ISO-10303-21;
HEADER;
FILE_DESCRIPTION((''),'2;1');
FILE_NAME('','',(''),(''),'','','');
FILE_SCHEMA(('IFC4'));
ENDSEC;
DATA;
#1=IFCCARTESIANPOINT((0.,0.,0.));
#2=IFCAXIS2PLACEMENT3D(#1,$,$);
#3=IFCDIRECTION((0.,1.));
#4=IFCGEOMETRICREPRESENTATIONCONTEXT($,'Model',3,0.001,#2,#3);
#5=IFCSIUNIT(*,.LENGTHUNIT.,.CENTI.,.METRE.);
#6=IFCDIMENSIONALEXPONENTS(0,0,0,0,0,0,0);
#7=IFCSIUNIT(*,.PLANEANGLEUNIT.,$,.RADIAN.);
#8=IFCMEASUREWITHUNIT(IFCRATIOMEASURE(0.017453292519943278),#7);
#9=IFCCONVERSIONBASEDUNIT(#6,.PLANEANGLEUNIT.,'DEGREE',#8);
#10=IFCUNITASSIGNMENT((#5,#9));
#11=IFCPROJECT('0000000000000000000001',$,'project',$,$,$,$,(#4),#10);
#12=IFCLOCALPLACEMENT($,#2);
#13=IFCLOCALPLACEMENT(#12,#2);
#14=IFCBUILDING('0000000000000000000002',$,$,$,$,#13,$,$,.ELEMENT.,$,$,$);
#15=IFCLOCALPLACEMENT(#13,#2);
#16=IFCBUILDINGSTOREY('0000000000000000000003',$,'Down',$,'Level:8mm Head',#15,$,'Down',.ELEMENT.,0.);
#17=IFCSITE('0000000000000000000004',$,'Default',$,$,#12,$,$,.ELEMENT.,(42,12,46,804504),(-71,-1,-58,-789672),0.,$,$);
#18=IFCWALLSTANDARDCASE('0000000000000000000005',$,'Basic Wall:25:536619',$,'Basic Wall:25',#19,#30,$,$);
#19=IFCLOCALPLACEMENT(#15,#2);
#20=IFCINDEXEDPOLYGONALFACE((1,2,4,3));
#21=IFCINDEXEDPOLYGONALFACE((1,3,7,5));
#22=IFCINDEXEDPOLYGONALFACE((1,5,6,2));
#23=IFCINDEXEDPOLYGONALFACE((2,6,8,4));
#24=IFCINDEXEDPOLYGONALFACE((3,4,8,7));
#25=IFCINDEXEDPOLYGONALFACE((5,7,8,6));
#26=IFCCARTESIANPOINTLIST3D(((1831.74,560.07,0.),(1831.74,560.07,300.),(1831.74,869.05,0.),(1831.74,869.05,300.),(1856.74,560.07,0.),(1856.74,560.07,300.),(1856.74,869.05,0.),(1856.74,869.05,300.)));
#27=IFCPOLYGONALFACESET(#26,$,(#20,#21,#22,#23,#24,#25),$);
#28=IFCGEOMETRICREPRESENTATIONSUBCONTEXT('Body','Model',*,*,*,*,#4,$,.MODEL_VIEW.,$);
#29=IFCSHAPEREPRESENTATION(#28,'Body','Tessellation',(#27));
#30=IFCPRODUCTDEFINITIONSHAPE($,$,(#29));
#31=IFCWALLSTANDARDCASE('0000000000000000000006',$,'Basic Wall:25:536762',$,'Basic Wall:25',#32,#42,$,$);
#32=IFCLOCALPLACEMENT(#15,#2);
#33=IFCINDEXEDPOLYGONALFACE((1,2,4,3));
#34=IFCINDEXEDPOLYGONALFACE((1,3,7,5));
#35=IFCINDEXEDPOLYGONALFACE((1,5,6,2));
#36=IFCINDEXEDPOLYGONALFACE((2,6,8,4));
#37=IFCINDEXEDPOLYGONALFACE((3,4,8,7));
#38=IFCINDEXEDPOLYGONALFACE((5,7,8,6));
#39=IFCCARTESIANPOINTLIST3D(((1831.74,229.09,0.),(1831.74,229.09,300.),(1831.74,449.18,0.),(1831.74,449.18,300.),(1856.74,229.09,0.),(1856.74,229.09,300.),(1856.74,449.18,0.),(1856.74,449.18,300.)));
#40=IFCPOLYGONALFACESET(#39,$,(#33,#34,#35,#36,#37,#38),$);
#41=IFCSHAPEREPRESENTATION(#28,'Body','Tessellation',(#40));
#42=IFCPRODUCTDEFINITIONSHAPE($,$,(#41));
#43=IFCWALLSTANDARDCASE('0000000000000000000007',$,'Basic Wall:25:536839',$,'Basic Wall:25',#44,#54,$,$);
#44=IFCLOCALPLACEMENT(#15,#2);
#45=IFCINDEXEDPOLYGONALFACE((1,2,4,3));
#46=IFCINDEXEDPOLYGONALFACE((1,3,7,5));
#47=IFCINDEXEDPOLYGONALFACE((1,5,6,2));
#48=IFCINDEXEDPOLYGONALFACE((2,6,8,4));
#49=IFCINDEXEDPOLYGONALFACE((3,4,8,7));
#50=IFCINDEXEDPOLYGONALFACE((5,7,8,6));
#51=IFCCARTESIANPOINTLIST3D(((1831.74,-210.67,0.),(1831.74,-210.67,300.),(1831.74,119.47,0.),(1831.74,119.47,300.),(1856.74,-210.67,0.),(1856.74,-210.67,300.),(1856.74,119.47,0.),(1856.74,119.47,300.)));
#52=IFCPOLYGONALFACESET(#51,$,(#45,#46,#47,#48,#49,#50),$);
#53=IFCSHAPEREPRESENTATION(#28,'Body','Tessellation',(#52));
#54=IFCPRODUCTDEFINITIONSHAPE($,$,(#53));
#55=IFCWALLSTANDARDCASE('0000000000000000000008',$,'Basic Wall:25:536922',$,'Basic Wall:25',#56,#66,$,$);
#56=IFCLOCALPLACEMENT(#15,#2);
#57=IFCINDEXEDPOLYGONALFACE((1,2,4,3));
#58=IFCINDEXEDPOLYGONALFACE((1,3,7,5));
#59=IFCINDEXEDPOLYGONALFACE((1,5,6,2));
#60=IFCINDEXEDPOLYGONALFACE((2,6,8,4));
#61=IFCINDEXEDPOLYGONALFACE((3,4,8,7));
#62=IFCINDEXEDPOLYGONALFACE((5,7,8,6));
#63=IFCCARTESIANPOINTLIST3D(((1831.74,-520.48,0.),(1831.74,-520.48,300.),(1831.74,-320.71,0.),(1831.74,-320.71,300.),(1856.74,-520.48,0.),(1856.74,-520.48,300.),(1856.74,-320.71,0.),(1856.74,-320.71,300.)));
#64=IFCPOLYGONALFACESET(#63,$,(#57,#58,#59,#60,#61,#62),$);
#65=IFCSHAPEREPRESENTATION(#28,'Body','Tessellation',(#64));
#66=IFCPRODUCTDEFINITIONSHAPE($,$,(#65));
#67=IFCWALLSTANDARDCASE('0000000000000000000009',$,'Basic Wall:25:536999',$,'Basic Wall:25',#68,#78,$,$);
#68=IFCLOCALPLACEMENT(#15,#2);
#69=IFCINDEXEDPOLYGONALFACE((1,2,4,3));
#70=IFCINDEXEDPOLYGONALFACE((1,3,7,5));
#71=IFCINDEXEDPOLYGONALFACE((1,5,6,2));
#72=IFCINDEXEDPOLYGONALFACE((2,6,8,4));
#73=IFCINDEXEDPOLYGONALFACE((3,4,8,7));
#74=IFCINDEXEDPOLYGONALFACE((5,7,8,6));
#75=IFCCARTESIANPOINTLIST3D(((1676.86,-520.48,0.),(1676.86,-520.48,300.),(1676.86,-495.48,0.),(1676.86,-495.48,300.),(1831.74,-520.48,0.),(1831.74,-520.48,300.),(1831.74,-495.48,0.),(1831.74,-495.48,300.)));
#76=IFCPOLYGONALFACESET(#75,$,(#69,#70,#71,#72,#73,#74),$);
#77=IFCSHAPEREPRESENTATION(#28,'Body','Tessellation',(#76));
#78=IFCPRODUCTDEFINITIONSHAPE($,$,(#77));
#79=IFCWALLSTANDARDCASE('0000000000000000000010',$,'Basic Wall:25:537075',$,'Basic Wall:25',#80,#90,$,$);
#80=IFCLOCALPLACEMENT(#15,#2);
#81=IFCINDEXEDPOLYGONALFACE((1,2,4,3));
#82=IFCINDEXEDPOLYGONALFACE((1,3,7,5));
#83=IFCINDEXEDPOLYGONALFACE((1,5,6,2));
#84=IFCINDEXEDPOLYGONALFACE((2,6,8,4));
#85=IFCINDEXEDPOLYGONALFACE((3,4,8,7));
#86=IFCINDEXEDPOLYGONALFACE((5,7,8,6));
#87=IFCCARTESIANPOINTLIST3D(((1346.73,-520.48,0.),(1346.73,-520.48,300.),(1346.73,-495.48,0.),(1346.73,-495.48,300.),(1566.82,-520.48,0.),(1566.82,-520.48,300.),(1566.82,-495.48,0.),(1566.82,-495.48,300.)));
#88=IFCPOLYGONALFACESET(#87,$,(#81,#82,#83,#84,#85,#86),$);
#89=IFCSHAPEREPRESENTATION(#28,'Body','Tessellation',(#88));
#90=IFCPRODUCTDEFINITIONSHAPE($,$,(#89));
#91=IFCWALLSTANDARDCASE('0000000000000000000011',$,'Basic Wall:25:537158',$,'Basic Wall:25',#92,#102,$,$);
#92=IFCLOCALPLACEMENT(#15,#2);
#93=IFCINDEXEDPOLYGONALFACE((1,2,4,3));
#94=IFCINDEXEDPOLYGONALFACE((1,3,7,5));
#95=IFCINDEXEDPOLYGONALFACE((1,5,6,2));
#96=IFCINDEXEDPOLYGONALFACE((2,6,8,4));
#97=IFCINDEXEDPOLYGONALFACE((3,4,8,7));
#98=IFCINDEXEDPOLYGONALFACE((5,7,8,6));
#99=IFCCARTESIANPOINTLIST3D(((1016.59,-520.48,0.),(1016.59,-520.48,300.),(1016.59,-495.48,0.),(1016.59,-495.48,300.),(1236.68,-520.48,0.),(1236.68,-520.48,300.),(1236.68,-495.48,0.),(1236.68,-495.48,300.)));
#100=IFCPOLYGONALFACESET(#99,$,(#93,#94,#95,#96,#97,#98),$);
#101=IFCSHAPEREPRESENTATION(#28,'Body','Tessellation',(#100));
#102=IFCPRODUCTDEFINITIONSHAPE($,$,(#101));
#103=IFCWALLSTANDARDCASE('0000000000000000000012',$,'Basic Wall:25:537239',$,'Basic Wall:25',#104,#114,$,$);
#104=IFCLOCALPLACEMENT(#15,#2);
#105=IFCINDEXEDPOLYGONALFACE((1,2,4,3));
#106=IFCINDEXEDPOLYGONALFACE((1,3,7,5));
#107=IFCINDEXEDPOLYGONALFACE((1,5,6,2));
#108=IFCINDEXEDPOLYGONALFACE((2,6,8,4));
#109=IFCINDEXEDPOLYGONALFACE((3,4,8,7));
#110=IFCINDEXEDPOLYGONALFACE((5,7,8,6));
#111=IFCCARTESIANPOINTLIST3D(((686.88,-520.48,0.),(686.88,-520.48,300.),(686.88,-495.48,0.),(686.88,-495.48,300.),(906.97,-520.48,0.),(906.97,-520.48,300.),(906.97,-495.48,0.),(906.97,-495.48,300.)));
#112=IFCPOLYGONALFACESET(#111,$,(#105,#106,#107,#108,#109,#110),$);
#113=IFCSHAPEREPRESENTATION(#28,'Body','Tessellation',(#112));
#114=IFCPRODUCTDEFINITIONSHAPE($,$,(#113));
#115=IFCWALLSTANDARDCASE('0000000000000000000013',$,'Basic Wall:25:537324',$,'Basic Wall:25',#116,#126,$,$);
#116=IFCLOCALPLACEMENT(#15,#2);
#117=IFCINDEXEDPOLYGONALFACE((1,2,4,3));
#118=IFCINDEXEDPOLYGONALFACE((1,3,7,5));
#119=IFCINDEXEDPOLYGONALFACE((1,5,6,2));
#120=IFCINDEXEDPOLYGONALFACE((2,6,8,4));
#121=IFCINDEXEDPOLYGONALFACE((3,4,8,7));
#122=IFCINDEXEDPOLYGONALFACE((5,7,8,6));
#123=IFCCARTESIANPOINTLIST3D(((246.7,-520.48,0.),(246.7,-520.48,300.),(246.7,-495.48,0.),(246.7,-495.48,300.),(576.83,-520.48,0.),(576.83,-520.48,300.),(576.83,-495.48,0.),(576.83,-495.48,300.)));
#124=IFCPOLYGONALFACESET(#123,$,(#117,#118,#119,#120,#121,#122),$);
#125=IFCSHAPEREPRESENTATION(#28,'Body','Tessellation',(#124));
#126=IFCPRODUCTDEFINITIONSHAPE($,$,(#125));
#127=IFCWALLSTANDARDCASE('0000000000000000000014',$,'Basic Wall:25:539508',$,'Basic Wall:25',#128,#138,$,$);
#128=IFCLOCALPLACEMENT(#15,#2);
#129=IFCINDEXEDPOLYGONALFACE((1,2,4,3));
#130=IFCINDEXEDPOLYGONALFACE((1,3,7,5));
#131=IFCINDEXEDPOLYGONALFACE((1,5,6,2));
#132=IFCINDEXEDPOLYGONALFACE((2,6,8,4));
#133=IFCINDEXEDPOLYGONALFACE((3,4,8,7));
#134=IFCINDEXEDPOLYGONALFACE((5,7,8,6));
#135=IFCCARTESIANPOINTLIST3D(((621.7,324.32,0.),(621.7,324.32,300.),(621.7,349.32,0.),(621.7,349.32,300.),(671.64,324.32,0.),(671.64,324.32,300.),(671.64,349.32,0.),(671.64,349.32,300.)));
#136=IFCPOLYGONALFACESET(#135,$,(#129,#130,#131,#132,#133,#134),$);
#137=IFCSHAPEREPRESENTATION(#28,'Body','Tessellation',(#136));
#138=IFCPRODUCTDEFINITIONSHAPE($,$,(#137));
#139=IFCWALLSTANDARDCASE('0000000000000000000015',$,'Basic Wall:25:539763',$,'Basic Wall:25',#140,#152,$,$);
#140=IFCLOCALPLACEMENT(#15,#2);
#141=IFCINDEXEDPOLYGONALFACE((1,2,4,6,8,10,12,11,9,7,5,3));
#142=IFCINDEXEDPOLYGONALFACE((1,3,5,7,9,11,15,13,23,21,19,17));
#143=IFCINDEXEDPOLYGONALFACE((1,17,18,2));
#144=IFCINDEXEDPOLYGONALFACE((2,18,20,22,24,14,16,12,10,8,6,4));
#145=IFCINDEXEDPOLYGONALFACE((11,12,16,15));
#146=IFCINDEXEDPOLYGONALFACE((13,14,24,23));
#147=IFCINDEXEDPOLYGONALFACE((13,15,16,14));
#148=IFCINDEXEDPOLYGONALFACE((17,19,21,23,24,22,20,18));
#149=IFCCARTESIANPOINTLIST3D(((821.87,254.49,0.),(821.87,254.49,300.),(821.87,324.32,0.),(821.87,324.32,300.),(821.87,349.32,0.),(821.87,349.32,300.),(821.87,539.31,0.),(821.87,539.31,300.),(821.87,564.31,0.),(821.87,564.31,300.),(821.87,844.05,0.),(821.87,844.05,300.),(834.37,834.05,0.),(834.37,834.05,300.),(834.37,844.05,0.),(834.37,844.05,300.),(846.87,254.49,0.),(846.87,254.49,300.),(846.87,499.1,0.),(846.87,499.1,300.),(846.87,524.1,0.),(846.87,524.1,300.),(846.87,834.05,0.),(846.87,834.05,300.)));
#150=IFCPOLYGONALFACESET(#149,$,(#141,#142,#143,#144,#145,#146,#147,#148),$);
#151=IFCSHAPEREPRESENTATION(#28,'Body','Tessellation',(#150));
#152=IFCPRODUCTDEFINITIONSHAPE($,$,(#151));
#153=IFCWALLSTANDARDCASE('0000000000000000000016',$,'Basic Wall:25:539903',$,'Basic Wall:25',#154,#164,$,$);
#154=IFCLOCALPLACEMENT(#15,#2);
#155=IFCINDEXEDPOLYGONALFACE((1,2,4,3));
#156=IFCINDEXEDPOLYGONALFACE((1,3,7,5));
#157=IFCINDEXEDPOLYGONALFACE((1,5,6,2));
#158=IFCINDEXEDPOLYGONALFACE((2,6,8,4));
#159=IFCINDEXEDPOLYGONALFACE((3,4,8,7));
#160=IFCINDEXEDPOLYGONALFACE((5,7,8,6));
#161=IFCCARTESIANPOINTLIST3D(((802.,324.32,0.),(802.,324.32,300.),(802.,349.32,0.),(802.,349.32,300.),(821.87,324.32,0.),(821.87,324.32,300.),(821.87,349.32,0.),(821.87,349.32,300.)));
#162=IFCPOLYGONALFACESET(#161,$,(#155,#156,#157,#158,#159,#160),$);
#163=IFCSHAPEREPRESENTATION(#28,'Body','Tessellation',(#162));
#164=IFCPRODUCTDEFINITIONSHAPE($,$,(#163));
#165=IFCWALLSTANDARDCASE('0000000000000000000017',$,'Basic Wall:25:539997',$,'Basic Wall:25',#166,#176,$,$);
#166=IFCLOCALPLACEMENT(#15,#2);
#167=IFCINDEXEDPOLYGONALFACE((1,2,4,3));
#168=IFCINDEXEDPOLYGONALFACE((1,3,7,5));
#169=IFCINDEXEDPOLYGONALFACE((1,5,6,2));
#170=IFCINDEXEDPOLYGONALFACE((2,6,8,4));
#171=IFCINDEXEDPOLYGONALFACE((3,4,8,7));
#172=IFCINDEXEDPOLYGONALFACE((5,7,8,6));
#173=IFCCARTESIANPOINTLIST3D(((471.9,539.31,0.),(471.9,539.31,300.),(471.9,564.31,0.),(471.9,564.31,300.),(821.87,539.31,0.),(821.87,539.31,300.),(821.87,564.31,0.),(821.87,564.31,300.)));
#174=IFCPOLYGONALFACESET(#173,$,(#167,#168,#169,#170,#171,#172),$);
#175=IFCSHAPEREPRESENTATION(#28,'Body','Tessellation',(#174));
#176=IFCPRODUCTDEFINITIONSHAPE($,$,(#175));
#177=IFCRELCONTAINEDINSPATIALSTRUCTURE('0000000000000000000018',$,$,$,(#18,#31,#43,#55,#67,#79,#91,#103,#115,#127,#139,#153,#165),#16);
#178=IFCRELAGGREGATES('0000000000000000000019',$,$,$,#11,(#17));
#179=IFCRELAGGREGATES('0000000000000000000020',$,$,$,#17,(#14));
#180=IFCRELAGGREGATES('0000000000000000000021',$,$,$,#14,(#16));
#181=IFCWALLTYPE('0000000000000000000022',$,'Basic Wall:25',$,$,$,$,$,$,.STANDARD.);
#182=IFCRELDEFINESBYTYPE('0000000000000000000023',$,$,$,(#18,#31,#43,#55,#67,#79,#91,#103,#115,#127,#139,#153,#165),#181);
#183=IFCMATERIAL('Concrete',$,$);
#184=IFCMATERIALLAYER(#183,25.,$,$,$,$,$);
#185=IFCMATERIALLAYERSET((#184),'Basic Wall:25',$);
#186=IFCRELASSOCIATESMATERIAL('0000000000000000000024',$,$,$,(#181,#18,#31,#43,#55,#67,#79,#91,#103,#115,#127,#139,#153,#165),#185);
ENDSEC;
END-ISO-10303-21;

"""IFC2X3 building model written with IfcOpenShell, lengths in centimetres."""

from ifc_helpers import new_model, entity, si_unit, converted_unit, direction, frame, frame_2d, origin, place, context, subcontext, project, spatial, polyline, rectangle, outline, extrude, material, layer, layer_set, layer_usage, type_object, element, save


model = new_model("IFC2X3")

# Units and contexts
model_context = context("Model", 3, precision=0.001, world=origin(), true_north=direction((0.0, 1.0)))
body_context = subcontext(model_context, "Body", "Model", "MODEL_VIEW")
ifc_project = project(units=[si_unit("LENGTHUNIT", "METRE", prefix="CENTI"), converted_unit("PLANEANGLEUNIT", "DEGREE", entity("IfcRatioMeasure", 0.017453292519943278), si_unit("PLANEANGLEUNIT", "RADIAN"), dimensions=[0, 0, 0, 0, 0, 0, 0])], contexts=[model_context])

# Site, building, storey
site_placement = place(None, origin())
site = spatial("IfcSite", under=ifc_project, at=site_placement, Name="Default", CompositionType="ELEMENT", RefLatitude=(42, 12, 46, 804504), RefLongitude=(-71, -1, -58, -789672), RefElevation=0.0)
building_placement = place(site_placement, origin())
building = spatial("IfcBuilding", under=site, at=building_placement, CompositionType="ELEMENT")
storey_placement = place(building_placement, origin())
storey = spatial("IfcBuildingStorey", under=building, at=storey_placement, Name="Down", ObjectType="Level:8mm Head", LongName="Down", CompositionType="ELEMENT", Elevation=0.0)

# Walls
ifc_material = material(Name="Concrete")
ifc_layer_1 = layer(ifc_material, 25.0)
ifc_layer_set_1 = layer_set([ifc_layer_1], Name="Basic Wall:25")
ifc_layer_usage_1 = layer_usage(ifc_layer_set_1, "AXIS2", "NEGATIVE", 12.5)
wall_type_1 = type_object("IfcWallType", Name="Basic Wall:25", PredefinedType="STANDARD", material=ifc_layer_set_1)
wall_1_placement = place(storey_placement, frame((1844.24, 869.05, 0.0), z_axis=(0.0, 0.0, 1.0), x_axis=(0.0, -1.0, 0.0)))
element("IfcWallStandardCase", 1, at=wall_1_placement, inside=storey, type_object=wall_type_1, material=ifc_layer_usage_1, Name="Basic Wall:25:536619", ObjectType="Basic Wall:25", context=body_context, shape_type="SweptSolid", body=[
    extrude(rectangle(XDim=308.97, YDim=25.0, at=frame_2d((154.49, 0.0), x_axis=(-1.0, 0.0))), origin(), (0.0, 0.0, 1.0), 300.0),
])
ifc_layer_usage_2 = layer_usage(ifc_layer_set_1, "AXIS2", "NEGATIVE", 12.5)
wall_2_placement = place(storey_placement, frame((1844.24, 449.18, 0.0), z_axis=(0.0, 0.0, 1.0), x_axis=(0.0, -1.0, 0.0)))
element("IfcWallStandardCase", 2, at=wall_2_placement, inside=storey, type_object=wall_type_1, material=ifc_layer_usage_2, Name="Basic Wall:25:536762", ObjectType="Basic Wall:25", context=body_context, shape_type="SweptSolid", body=[
    extrude(rectangle(XDim=220.09, YDim=25.0, at=frame_2d((110.05, 0.0), x_axis=(-1.0, 0.0))), origin(), (0.0, 0.0, 1.0), 300.0),
])
ifc_layer_usage_3 = layer_usage(ifc_layer_set_1, "AXIS2", "NEGATIVE", 12.5)
wall_3_placement = place(storey_placement, frame((1844.24, 119.47, 0.0), z_axis=(0.0, 0.0, 1.0), x_axis=(0.0, -1.0, 0.0)))
element("IfcWallStandardCase", 3, at=wall_3_placement, inside=storey, type_object=wall_type_1, material=ifc_layer_usage_3, Name="Basic Wall:25:536839", ObjectType="Basic Wall:25", context=body_context, shape_type="SweptSolid", body=[
    extrude(rectangle(XDim=330.14, YDim=25.0, at=frame_2d((165.07, 0.0), x_axis=(-1.0, 0.0))), origin(), (0.0, 0.0, 1.0), 300.0),
])
ifc_layer_usage_4 = layer_usage(ifc_layer_set_1, "AXIS2", "NEGATIVE", 12.5)
wall_4_placement = place(storey_placement, frame((1844.24, -320.71, 0.0), z_axis=(0.0, 0.0, 1.0), x_axis=(0.0, -1.0, 0.0)))
element("IfcWallStandardCase", 4, at=wall_4_placement, inside=storey, type_object=wall_type_1, material=ifc_layer_usage_4, Name="Basic Wall:25:536922", ObjectType="Basic Wall:25", context=body_context, shape_type="SweptSolid", body=[
    extrude(rectangle(XDim=199.77, YDim=25.0, at=frame_2d((99.89, 0.0), x_axis=(-1.0, 0.0))), origin(), (0.0, 0.0, 1.0), 300.0),
])
ifc_layer_usage_5 = layer_usage(ifc_layer_set_1, "AXIS2", "NEGATIVE", 12.5)
wall_5_placement = place(storey_placement, frame((1831.74, -507.98, 0.0), z_axis=(0.0, 0.0, 1.0), x_axis=(-1.0, 0.0, 0.0)))
element("IfcWallStandardCase", 5, at=wall_5_placement, inside=storey, type_object=wall_type_1, material=ifc_layer_usage_5, Name="Basic Wall:25:536999", ObjectType="Basic Wall:25", context=body_context, shape_type="SweptSolid", body=[
    extrude(rectangle(XDim=154.88, YDim=25.0, at=frame_2d((77.44, 0.0), x_axis=(-1.0, 0.0))), origin(), (0.0, 0.0, 1.0), 300.0),
])
ifc_layer_usage_6 = layer_usage(ifc_layer_set_1, "AXIS2", "NEGATIVE", 12.5)
wall_6_placement = place(storey_placement, frame((1566.82, -507.98, 0.0), z_axis=(0.0, 0.0, 1.0), x_axis=(-1.0, 0.0, 0.0)))
element("IfcWallStandardCase", 6, at=wall_6_placement, inside=storey, type_object=wall_type_1, material=ifc_layer_usage_6, Name="Basic Wall:25:537075", ObjectType="Basic Wall:25", context=body_context, shape_type="SweptSolid", body=[
    extrude(rectangle(XDim=220.09, YDim=25.0, at=frame_2d((110.05, 0.0), x_axis=(-1.0, 0.0))), origin(), (0.0, 0.0, 1.0), 300.0),
])
ifc_layer_usage_7 = layer_usage(ifc_layer_set_1, "AXIS2", "NEGATIVE", 12.5)
wall_7_placement = place(storey_placement, frame((1236.68, -507.98, 0.0), z_axis=(0.0, 0.0, 1.0), x_axis=(-1.0, 0.0, 0.0)))
element("IfcWallStandardCase", 7, at=wall_7_placement, inside=storey, type_object=wall_type_1, material=ifc_layer_usage_7, Name="Basic Wall:25:537158", ObjectType="Basic Wall:25", context=body_context, shape_type="SweptSolid", body=[
    extrude(rectangle(XDim=220.09, YDim=25.0, at=frame_2d((110.05, 0.0), x_axis=(-1.0, 0.0))), origin(), (0.0, 0.0, 1.0), 300.0),
])
ifc_layer_usage_8 = layer_usage(ifc_layer_set_1, "AXIS2", "NEGATIVE", 12.5)
wall_8_placement = place(storey_placement, frame((906.97, -507.98, 0.0), z_axis=(0.0, 0.0, 1.0), x_axis=(-1.0, 0.0, 0.0)))
element("IfcWallStandardCase", 8, at=wall_8_placement, inside=storey, type_object=wall_type_1, material=ifc_layer_usage_8, Name="Basic Wall:25:537239", ObjectType="Basic Wall:25", context=body_context, shape_type="SweptSolid", body=[
    extrude(rectangle(XDim=220.09, YDim=25.0, at=frame_2d((110.05, 0.0), x_axis=(-1.0, 0.0))), origin(), (0.0, 0.0, 1.0), 300.0),
])
ifc_layer_usage_9 = layer_usage(ifc_layer_set_1, "AXIS2", "NEGATIVE", 12.5)
wall_9_placement = place(storey_placement, frame((576.83, -507.98, 0.0), z_axis=(0.0, 0.0, 1.0), x_axis=(-1.0, 0.0, 0.0)))
element("IfcWallStandardCase", 9, at=wall_9_placement, inside=storey, type_object=wall_type_1, material=ifc_layer_usage_9, Name="Basic Wall:25:537324", ObjectType="Basic Wall:25", context=body_context, shape_type="SweptSolid", body=[
    extrude(rectangle(XDim=330.14, YDim=25.0, at=frame_2d((165.07, 0.0), x_axis=(-1.0, 0.0))), origin(), (0.0, 0.0, 1.0), 300.0),
])
ifc_layer_usage_10 = layer_usage(ifc_layer_set_1, "AXIS2", "POSITIVE", -12.5)
wall_10_placement = place(storey_placement, frame((621.7, 336.82, 0.0)))
element("IfcWallStandardCase", 10, at=wall_10_placement, inside=storey, type_object=wall_type_1, material=ifc_layer_usage_10, Name="Basic Wall:25:539508", ObjectType="Basic Wall:25", context=body_context, shape_type="SweptSolid", body=[
    extrude(rectangle(XDim=49.94, YDim=25.0, at=frame_2d((24.97, 0.0), x_axis=(-1.0, 0.0))), origin(), (0.0, 0.0, 1.0), 300.0),
])
ifc_layer_usage_11 = layer_usage(ifc_layer_set_1, "AXIS2", "POSITIVE", -12.5)
wall_11_placement = place(storey_placement, frame((834.37, 254.49, 0.0), z_axis=(0.0, 0.0, 1.0), x_axis=(0.0, 1.0, 0.0)))
element("IfcWallStandardCase", 11, at=wall_11_placement, inside=storey, type_object=wall_type_1, material=ifc_layer_usage_11, Name="Basic Wall:25:539763", ObjectType="Basic Wall:25", context=body_context, shape_type="SweptSolid", body=[
    extrude(outline(polyline([(579.56, -12.5), (579.56, 0.0), (589.56, 0.0), (589.56, 12.5), (309.82, 12.5), (284.82, 12.5), (94.84, 12.5), (69.84, 12.5), (0.0, 12.5), (0.0, -12.5), (244.61, -12.5), (269.61, -12.5), (579.56, -12.5)])), origin(), (0.0, 0.0, 1.0), 300.0),
])
ifc_layer_usage_12 = layer_usage(ifc_layer_set_1, "AXIS2", "POSITIVE", -12.5)
wall_12_placement = place(storey_placement, frame((802.0, 336.82, 0.0)))
element("IfcWallStandardCase", 12, at=wall_12_placement, inside=storey, type_object=wall_type_1, material=ifc_layer_usage_12, Name="Basic Wall:25:539903", ObjectType="Basic Wall:25", context=body_context, shape_type="SweptSolid", body=[
    extrude(rectangle(XDim=19.86, YDim=25.0, at=frame_2d((9.93, 0.0), x_axis=(-1.0, 0.0))), origin(), (0.0, 0.0, 1.0), 300.0),
])
ifc_layer_usage_13 = layer_usage(ifc_layer_set_1, "AXIS2", "NEGATIVE", 12.5)
wall_13_placement = place(storey_placement, frame((471.9, 551.81, 0.0)))
element("IfcWallStandardCase", 13, at=wall_13_placement, inside=storey, type_object=wall_type_1, material=ifc_layer_usage_13, Name="Basic Wall:25:539997", ObjectType="Basic Wall:25", context=body_context, shape_type="SweptSolid", body=[
    extrude(rectangle(XDim=349.97, YDim=25.0, at=frame_2d((174.99, 0.0), x_axis=(-1.0, 0.0))), origin(), (0.0, 0.0, 1.0), 300.0),
])

save(model, "model.ifc")
